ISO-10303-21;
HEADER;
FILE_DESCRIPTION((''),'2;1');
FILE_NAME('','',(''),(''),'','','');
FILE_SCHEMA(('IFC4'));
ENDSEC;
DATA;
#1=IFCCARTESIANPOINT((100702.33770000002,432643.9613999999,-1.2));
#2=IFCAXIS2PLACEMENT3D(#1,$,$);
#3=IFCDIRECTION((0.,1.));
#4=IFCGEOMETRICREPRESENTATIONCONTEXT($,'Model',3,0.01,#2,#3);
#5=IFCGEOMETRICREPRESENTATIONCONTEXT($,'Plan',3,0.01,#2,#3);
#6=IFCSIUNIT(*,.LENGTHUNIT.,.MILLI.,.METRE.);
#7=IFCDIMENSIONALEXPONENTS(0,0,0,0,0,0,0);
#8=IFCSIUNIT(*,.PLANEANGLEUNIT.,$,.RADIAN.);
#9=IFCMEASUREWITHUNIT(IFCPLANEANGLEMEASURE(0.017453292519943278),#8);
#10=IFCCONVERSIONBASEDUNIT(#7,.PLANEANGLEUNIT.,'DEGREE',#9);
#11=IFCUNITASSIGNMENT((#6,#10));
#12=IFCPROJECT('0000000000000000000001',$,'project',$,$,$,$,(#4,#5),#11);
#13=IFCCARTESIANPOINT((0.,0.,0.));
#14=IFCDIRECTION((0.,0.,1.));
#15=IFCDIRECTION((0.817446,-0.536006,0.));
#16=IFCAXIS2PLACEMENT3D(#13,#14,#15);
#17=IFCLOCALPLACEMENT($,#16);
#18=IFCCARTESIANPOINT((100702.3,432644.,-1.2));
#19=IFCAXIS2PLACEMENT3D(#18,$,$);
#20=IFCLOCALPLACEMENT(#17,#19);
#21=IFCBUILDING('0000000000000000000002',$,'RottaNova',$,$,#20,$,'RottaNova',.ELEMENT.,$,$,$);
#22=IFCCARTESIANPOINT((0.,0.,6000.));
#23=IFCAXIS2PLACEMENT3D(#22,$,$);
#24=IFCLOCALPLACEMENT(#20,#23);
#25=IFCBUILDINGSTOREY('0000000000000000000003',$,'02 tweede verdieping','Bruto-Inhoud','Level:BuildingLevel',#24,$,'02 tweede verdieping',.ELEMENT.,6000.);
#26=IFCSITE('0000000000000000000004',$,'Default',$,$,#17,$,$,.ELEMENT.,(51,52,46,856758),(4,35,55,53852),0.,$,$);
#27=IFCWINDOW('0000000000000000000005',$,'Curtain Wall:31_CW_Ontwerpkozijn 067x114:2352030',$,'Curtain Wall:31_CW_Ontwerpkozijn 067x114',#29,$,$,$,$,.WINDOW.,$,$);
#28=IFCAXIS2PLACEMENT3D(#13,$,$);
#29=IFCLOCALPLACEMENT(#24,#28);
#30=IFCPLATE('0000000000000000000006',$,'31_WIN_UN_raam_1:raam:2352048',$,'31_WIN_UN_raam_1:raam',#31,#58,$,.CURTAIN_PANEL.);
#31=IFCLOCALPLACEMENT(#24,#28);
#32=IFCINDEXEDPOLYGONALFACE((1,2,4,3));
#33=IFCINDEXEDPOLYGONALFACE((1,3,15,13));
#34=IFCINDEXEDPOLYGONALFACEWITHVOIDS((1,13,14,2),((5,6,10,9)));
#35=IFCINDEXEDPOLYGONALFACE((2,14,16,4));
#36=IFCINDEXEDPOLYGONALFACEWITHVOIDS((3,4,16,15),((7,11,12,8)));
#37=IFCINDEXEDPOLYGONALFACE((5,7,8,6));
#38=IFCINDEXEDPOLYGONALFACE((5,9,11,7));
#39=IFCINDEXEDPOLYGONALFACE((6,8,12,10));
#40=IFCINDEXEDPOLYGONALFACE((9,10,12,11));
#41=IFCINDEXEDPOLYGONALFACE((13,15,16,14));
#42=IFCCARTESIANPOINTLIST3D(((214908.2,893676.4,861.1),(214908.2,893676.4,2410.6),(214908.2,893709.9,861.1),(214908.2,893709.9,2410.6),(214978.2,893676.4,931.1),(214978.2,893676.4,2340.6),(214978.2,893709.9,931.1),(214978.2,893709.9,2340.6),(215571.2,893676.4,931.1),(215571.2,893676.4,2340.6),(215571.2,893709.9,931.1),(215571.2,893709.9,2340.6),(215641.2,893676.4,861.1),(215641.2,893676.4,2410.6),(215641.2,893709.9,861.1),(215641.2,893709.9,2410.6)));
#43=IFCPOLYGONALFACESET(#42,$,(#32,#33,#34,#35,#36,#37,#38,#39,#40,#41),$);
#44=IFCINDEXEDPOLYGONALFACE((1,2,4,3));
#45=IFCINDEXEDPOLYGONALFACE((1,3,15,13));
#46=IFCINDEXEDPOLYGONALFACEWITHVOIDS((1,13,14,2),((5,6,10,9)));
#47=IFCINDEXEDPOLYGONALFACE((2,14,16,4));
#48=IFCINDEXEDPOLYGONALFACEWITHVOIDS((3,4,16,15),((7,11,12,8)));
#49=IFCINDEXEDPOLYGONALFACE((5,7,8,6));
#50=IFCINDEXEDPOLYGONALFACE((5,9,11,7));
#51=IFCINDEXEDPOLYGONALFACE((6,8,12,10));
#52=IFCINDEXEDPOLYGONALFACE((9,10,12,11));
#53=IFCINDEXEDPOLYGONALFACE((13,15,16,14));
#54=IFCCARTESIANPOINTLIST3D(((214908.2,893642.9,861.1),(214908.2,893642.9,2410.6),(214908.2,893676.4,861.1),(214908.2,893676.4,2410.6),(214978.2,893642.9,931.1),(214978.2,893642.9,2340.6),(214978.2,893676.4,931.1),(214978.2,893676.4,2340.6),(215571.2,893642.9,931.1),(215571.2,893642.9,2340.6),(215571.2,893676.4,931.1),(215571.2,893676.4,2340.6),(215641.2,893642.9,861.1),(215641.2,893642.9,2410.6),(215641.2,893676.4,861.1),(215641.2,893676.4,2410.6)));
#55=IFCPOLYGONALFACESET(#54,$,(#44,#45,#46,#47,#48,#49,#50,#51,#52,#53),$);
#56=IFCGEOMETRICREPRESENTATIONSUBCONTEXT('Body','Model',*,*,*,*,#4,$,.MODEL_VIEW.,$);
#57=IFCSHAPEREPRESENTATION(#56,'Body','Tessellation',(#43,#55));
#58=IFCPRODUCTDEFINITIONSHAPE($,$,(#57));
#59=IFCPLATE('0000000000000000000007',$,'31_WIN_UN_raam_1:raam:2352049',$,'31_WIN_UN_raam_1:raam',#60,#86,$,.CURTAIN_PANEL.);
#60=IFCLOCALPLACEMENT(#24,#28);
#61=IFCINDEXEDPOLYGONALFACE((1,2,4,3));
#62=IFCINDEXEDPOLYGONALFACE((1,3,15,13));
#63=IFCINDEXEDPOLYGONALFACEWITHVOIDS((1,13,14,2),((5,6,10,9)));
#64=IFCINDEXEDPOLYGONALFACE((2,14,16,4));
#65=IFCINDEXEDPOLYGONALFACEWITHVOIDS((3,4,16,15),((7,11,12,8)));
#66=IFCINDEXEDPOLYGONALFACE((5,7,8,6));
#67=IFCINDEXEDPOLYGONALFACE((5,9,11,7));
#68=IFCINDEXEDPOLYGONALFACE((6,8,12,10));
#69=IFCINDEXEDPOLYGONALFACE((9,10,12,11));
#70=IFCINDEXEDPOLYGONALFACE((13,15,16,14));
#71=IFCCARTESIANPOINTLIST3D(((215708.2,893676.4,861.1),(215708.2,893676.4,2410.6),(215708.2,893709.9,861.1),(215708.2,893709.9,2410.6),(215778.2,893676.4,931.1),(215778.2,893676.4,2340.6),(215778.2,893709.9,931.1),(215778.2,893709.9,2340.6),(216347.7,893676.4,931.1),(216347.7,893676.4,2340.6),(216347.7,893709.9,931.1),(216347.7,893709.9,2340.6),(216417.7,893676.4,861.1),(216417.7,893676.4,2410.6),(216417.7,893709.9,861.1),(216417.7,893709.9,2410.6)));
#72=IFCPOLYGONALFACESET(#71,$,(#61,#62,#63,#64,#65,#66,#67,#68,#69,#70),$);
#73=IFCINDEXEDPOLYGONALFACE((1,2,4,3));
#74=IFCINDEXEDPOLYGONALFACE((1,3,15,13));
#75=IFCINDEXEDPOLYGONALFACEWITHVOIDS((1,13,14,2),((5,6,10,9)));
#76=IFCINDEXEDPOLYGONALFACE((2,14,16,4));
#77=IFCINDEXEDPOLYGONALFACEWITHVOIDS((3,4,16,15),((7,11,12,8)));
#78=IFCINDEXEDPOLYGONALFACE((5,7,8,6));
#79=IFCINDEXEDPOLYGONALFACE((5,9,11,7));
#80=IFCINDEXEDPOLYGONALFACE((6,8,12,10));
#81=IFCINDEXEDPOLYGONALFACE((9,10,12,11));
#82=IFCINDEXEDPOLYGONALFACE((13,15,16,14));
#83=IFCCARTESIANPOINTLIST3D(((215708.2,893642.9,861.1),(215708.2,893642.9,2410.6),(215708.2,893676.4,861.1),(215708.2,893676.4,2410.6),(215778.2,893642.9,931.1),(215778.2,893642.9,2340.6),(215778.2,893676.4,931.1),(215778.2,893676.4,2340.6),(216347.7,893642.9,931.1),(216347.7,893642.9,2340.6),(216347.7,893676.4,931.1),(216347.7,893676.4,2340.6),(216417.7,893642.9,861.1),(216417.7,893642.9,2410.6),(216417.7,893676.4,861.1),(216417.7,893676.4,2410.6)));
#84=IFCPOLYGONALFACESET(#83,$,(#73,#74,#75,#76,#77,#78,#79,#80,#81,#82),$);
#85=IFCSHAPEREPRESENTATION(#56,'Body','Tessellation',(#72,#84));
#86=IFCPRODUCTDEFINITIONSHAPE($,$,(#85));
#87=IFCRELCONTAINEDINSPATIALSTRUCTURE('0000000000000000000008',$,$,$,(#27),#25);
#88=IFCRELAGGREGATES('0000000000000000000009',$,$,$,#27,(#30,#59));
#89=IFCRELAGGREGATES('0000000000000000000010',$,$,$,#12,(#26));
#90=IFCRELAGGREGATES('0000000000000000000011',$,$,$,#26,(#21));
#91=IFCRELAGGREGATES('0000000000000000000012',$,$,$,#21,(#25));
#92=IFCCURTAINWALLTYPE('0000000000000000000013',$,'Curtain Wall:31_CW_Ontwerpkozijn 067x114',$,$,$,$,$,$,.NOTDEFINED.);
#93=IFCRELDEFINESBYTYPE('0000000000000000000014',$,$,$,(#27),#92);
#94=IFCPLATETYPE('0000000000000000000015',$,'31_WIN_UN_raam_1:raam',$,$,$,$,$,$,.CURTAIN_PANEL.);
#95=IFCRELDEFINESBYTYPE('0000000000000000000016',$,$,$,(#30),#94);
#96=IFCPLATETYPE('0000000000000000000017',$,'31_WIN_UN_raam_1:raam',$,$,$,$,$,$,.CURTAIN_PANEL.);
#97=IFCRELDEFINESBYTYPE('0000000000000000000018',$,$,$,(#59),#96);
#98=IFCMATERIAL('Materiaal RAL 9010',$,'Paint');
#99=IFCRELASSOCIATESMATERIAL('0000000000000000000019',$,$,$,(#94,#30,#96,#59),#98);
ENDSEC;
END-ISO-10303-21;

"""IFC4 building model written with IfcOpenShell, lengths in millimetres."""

from ifc_helpers import new_model, entity, si_unit, converted_unit, direction, frame, place, context, subcontext, project, spatial, indexed_curve, outline, extrude, source, transform, mapped, material, type_object, type_shapes, element, aggregate, save


model = new_model("IFC4")

# Units and contexts
model_context = context("Model", 3, precision=0.01, world=frame((100702.33770000002, 432643.9613999999, -1.2)), true_north=direction((0.0, 1.0)))
plan_context = context("Plan", 3, precision=0.01, world=frame((100702.33770000002, 432643.9613999999, -1.2)), true_north=direction((0.0, 1.0)))
body_context = subcontext(model_context, "Body", "Model", "MODEL_VIEW")
ifc_project = project(units=[si_unit("LENGTHUNIT", "METRE", prefix="MILLI"), converted_unit("PLANEANGLEUNIT", "DEGREE", entity("IfcPlaneAngleMeasure", 0.017453292519943278), si_unit("PLANEANGLEUNIT", "RADIAN"), dimensions=[0, 0, 0, 0, 0, 0, 0])], contexts=[model_context, plan_context])

# Site, building, storey
site_placement = place(None, frame((0.0, 0.0, 0.0), z_axis=(0.0, 0.0, 1.0), x_axis=(0.817446, -0.536006, 0.0)))
site = spatial("IfcSite", under=ifc_project, at=site_placement, Name="Default", CompositionType="ELEMENT", RefLatitude=(51, 52, 46, 856758), RefLongitude=(4, 35, 55, 53852), RefElevation=0.0)
building_placement = place(site_placement, frame((100702.3, 432644.0, -1.2)))
building = spatial("IfcBuilding", under=site, at=building_placement, Name="RottaNova", LongName="RottaNova", CompositionType="ELEMENT")
storey_placement = place(building_placement, frame((0.0, 0.0, 6000.0)))
storey = spatial("IfcBuildingStorey", under=building, at=storey_placement, Name="02 tweede verdieping", Description="Bruto-Inhoud", ObjectType="Level:BuildingLevel", LongName="02 tweede verdieping", CompositionType="ELEMENT", Elevation=6000.0)

# Window
curtain_wall_type = type_object("IfcCurtainWallType", Name="Curtain Wall:31_CW_Ontwerpkozijn 067x114", PredefinedType="NOTDEFINED")
window_1_placement = place(storey_placement, frame((0.0, 0.0, -6000.0)))
window_1 = element("IfcWindow", 1, at=window_1_placement, inside=storey, type_object=curtain_wall_type, Name="Curtain Wall:31_CW_Ontwerpkozijn 067x114:2352030", ObjectType="Curtain Wall:31_CW_Ontwerpkozijn 067x114", PredefinedType="WINDOW")

# Plates
ifc_material_1 = material(Name="Materiaal RAL 9010", Category="Paint")
plate_type_1 = type_object("IfcPlateType", Name="31_WIN_UN_raam_1:raam", PredefinedType="CURTAIN_PANEL", material=ifc_material_1)
shared_shape_1 = source(frame((100702.3, 432644.0, -1.2)), body_context, "Body", "SweptSolid", [
    extrude(outline(indexed_curve([(-366.5, -774.8), (366.5, -774.8), (366.5, 774.8), (-366.5, 774.8), (-366.5, -774.8)], self_intersect=False), holes=[indexed_curve([(-296.5, 704.8), (296.5, 704.8), (296.5, -704.8), (-296.5, -704.8), (-296.5, 704.8)], self_intersect=False)]), frame((0.0, 58.5, 774.8), z_axis=(0.0, 1.0, 0.0), x_axis=(1.0, 0.0, 0.0)), (0.0, 0.0, 1.0), 33.5),
    extrude(outline(indexed_curve([(-366.5, -774.8), (366.5, -774.8), (366.5, 774.8), (-366.5, 774.8), (-366.5, -774.8)], self_intersect=False), holes=[indexed_curve([(-296.5, 704.7), (296.5, 704.7), (296.5, -704.8), (-296.5, -704.8), (-296.5, 704.7)], self_intersect=False)]), frame((0.0, 25.0, 774.8), z_axis=(0.0, 1.0, 0.0), x_axis=(1.0, 0.0, 0.0)), (0.0, 0.0, 1.0), 33.5),
])
type_shapes(plate_type_1, [shared_shape_1])
plate_1_placement = place(window_1_placement, frame((13870.0, 28330.0, 6863.5)))
plate_1 = element("IfcPlate", 2, at=plate_1_placement, type_object=plate_type_1, material=ifc_material_1, Name="31_WIN_UN_raam_1:raam:2352048", ObjectType="31_WIN_UN_raam_1:raam", PredefinedType="CURTAIN_PANEL", context=body_context, shape_type="MappedRepresentation", body=[
    mapped(shared_shape_1, transform((100702.3, 432644.0, -1.2), scale=1.0)),
])
plate_type_2 = type_object("IfcPlateType", Name="31_WIN_UN_raam_1:raam", PredefinedType="CURTAIN_PANEL", material=ifc_material_1)
shared_shape_2 = source(frame((100702.3, 432644.0, -1.2)), body_context, "Body", "SweptSolid", [
    extrude(outline(indexed_curve([(-354.8, -774.7), (354.8, -774.7), (354.8, 774.7), (-354.8, 774.7), (-354.8, -774.7)], self_intersect=False), holes=[indexed_curve([(-284.8, 704.7), (284.8, 704.7), (284.8, -704.8), (-284.8, -704.8), (-284.8, 704.7)], self_intersect=False)]), frame((0.0, 58.5, 774.8), z_axis=(0.0, 1.0, 0.0), x_axis=(1.0, 0.0, 0.0)), (0.0, 0.0, 1.0), 33.5),
    extrude(outline(indexed_curve([(-354.8, -774.7), (354.8, -774.7), (354.8, 774.7), (-354.8, 774.7), (-354.8, -774.7)], self_intersect=False), holes=[indexed_curve([(-284.8, 704.7), (284.8, 704.7), (284.8, -704.8), (-284.8, -704.8), (-284.8, 704.7)], self_intersect=False)]), frame((0.0, 25.0, 774.8), z_axis=(0.0, 1.0, 0.0), x_axis=(1.0, 0.0, 0.0)), (0.0, 0.0, 1.0), 33.5),
])
type_shapes(plate_type_2, [shared_shape_2])
plate_2_placement = place(window_1_placement, frame((14658.3, 28330.0, 6863.5)))
plate_2 = element("IfcPlate", 3, at=plate_2_placement, type_object=plate_type_2, material=ifc_material_1, Name="31_WIN_UN_raam_1:raam:2352049", ObjectType="31_WIN_UN_raam_1:raam", PredefinedType="CURTAIN_PANEL", context=body_context, shape_type="MappedRepresentation", body=[
    mapped(shared_shape_2, transform((100702.3, 432644.0, -1.2), scale=1.0)),
])
aggregate(window_1, [plate_1, plate_2])

save(model, "model.ifc")
